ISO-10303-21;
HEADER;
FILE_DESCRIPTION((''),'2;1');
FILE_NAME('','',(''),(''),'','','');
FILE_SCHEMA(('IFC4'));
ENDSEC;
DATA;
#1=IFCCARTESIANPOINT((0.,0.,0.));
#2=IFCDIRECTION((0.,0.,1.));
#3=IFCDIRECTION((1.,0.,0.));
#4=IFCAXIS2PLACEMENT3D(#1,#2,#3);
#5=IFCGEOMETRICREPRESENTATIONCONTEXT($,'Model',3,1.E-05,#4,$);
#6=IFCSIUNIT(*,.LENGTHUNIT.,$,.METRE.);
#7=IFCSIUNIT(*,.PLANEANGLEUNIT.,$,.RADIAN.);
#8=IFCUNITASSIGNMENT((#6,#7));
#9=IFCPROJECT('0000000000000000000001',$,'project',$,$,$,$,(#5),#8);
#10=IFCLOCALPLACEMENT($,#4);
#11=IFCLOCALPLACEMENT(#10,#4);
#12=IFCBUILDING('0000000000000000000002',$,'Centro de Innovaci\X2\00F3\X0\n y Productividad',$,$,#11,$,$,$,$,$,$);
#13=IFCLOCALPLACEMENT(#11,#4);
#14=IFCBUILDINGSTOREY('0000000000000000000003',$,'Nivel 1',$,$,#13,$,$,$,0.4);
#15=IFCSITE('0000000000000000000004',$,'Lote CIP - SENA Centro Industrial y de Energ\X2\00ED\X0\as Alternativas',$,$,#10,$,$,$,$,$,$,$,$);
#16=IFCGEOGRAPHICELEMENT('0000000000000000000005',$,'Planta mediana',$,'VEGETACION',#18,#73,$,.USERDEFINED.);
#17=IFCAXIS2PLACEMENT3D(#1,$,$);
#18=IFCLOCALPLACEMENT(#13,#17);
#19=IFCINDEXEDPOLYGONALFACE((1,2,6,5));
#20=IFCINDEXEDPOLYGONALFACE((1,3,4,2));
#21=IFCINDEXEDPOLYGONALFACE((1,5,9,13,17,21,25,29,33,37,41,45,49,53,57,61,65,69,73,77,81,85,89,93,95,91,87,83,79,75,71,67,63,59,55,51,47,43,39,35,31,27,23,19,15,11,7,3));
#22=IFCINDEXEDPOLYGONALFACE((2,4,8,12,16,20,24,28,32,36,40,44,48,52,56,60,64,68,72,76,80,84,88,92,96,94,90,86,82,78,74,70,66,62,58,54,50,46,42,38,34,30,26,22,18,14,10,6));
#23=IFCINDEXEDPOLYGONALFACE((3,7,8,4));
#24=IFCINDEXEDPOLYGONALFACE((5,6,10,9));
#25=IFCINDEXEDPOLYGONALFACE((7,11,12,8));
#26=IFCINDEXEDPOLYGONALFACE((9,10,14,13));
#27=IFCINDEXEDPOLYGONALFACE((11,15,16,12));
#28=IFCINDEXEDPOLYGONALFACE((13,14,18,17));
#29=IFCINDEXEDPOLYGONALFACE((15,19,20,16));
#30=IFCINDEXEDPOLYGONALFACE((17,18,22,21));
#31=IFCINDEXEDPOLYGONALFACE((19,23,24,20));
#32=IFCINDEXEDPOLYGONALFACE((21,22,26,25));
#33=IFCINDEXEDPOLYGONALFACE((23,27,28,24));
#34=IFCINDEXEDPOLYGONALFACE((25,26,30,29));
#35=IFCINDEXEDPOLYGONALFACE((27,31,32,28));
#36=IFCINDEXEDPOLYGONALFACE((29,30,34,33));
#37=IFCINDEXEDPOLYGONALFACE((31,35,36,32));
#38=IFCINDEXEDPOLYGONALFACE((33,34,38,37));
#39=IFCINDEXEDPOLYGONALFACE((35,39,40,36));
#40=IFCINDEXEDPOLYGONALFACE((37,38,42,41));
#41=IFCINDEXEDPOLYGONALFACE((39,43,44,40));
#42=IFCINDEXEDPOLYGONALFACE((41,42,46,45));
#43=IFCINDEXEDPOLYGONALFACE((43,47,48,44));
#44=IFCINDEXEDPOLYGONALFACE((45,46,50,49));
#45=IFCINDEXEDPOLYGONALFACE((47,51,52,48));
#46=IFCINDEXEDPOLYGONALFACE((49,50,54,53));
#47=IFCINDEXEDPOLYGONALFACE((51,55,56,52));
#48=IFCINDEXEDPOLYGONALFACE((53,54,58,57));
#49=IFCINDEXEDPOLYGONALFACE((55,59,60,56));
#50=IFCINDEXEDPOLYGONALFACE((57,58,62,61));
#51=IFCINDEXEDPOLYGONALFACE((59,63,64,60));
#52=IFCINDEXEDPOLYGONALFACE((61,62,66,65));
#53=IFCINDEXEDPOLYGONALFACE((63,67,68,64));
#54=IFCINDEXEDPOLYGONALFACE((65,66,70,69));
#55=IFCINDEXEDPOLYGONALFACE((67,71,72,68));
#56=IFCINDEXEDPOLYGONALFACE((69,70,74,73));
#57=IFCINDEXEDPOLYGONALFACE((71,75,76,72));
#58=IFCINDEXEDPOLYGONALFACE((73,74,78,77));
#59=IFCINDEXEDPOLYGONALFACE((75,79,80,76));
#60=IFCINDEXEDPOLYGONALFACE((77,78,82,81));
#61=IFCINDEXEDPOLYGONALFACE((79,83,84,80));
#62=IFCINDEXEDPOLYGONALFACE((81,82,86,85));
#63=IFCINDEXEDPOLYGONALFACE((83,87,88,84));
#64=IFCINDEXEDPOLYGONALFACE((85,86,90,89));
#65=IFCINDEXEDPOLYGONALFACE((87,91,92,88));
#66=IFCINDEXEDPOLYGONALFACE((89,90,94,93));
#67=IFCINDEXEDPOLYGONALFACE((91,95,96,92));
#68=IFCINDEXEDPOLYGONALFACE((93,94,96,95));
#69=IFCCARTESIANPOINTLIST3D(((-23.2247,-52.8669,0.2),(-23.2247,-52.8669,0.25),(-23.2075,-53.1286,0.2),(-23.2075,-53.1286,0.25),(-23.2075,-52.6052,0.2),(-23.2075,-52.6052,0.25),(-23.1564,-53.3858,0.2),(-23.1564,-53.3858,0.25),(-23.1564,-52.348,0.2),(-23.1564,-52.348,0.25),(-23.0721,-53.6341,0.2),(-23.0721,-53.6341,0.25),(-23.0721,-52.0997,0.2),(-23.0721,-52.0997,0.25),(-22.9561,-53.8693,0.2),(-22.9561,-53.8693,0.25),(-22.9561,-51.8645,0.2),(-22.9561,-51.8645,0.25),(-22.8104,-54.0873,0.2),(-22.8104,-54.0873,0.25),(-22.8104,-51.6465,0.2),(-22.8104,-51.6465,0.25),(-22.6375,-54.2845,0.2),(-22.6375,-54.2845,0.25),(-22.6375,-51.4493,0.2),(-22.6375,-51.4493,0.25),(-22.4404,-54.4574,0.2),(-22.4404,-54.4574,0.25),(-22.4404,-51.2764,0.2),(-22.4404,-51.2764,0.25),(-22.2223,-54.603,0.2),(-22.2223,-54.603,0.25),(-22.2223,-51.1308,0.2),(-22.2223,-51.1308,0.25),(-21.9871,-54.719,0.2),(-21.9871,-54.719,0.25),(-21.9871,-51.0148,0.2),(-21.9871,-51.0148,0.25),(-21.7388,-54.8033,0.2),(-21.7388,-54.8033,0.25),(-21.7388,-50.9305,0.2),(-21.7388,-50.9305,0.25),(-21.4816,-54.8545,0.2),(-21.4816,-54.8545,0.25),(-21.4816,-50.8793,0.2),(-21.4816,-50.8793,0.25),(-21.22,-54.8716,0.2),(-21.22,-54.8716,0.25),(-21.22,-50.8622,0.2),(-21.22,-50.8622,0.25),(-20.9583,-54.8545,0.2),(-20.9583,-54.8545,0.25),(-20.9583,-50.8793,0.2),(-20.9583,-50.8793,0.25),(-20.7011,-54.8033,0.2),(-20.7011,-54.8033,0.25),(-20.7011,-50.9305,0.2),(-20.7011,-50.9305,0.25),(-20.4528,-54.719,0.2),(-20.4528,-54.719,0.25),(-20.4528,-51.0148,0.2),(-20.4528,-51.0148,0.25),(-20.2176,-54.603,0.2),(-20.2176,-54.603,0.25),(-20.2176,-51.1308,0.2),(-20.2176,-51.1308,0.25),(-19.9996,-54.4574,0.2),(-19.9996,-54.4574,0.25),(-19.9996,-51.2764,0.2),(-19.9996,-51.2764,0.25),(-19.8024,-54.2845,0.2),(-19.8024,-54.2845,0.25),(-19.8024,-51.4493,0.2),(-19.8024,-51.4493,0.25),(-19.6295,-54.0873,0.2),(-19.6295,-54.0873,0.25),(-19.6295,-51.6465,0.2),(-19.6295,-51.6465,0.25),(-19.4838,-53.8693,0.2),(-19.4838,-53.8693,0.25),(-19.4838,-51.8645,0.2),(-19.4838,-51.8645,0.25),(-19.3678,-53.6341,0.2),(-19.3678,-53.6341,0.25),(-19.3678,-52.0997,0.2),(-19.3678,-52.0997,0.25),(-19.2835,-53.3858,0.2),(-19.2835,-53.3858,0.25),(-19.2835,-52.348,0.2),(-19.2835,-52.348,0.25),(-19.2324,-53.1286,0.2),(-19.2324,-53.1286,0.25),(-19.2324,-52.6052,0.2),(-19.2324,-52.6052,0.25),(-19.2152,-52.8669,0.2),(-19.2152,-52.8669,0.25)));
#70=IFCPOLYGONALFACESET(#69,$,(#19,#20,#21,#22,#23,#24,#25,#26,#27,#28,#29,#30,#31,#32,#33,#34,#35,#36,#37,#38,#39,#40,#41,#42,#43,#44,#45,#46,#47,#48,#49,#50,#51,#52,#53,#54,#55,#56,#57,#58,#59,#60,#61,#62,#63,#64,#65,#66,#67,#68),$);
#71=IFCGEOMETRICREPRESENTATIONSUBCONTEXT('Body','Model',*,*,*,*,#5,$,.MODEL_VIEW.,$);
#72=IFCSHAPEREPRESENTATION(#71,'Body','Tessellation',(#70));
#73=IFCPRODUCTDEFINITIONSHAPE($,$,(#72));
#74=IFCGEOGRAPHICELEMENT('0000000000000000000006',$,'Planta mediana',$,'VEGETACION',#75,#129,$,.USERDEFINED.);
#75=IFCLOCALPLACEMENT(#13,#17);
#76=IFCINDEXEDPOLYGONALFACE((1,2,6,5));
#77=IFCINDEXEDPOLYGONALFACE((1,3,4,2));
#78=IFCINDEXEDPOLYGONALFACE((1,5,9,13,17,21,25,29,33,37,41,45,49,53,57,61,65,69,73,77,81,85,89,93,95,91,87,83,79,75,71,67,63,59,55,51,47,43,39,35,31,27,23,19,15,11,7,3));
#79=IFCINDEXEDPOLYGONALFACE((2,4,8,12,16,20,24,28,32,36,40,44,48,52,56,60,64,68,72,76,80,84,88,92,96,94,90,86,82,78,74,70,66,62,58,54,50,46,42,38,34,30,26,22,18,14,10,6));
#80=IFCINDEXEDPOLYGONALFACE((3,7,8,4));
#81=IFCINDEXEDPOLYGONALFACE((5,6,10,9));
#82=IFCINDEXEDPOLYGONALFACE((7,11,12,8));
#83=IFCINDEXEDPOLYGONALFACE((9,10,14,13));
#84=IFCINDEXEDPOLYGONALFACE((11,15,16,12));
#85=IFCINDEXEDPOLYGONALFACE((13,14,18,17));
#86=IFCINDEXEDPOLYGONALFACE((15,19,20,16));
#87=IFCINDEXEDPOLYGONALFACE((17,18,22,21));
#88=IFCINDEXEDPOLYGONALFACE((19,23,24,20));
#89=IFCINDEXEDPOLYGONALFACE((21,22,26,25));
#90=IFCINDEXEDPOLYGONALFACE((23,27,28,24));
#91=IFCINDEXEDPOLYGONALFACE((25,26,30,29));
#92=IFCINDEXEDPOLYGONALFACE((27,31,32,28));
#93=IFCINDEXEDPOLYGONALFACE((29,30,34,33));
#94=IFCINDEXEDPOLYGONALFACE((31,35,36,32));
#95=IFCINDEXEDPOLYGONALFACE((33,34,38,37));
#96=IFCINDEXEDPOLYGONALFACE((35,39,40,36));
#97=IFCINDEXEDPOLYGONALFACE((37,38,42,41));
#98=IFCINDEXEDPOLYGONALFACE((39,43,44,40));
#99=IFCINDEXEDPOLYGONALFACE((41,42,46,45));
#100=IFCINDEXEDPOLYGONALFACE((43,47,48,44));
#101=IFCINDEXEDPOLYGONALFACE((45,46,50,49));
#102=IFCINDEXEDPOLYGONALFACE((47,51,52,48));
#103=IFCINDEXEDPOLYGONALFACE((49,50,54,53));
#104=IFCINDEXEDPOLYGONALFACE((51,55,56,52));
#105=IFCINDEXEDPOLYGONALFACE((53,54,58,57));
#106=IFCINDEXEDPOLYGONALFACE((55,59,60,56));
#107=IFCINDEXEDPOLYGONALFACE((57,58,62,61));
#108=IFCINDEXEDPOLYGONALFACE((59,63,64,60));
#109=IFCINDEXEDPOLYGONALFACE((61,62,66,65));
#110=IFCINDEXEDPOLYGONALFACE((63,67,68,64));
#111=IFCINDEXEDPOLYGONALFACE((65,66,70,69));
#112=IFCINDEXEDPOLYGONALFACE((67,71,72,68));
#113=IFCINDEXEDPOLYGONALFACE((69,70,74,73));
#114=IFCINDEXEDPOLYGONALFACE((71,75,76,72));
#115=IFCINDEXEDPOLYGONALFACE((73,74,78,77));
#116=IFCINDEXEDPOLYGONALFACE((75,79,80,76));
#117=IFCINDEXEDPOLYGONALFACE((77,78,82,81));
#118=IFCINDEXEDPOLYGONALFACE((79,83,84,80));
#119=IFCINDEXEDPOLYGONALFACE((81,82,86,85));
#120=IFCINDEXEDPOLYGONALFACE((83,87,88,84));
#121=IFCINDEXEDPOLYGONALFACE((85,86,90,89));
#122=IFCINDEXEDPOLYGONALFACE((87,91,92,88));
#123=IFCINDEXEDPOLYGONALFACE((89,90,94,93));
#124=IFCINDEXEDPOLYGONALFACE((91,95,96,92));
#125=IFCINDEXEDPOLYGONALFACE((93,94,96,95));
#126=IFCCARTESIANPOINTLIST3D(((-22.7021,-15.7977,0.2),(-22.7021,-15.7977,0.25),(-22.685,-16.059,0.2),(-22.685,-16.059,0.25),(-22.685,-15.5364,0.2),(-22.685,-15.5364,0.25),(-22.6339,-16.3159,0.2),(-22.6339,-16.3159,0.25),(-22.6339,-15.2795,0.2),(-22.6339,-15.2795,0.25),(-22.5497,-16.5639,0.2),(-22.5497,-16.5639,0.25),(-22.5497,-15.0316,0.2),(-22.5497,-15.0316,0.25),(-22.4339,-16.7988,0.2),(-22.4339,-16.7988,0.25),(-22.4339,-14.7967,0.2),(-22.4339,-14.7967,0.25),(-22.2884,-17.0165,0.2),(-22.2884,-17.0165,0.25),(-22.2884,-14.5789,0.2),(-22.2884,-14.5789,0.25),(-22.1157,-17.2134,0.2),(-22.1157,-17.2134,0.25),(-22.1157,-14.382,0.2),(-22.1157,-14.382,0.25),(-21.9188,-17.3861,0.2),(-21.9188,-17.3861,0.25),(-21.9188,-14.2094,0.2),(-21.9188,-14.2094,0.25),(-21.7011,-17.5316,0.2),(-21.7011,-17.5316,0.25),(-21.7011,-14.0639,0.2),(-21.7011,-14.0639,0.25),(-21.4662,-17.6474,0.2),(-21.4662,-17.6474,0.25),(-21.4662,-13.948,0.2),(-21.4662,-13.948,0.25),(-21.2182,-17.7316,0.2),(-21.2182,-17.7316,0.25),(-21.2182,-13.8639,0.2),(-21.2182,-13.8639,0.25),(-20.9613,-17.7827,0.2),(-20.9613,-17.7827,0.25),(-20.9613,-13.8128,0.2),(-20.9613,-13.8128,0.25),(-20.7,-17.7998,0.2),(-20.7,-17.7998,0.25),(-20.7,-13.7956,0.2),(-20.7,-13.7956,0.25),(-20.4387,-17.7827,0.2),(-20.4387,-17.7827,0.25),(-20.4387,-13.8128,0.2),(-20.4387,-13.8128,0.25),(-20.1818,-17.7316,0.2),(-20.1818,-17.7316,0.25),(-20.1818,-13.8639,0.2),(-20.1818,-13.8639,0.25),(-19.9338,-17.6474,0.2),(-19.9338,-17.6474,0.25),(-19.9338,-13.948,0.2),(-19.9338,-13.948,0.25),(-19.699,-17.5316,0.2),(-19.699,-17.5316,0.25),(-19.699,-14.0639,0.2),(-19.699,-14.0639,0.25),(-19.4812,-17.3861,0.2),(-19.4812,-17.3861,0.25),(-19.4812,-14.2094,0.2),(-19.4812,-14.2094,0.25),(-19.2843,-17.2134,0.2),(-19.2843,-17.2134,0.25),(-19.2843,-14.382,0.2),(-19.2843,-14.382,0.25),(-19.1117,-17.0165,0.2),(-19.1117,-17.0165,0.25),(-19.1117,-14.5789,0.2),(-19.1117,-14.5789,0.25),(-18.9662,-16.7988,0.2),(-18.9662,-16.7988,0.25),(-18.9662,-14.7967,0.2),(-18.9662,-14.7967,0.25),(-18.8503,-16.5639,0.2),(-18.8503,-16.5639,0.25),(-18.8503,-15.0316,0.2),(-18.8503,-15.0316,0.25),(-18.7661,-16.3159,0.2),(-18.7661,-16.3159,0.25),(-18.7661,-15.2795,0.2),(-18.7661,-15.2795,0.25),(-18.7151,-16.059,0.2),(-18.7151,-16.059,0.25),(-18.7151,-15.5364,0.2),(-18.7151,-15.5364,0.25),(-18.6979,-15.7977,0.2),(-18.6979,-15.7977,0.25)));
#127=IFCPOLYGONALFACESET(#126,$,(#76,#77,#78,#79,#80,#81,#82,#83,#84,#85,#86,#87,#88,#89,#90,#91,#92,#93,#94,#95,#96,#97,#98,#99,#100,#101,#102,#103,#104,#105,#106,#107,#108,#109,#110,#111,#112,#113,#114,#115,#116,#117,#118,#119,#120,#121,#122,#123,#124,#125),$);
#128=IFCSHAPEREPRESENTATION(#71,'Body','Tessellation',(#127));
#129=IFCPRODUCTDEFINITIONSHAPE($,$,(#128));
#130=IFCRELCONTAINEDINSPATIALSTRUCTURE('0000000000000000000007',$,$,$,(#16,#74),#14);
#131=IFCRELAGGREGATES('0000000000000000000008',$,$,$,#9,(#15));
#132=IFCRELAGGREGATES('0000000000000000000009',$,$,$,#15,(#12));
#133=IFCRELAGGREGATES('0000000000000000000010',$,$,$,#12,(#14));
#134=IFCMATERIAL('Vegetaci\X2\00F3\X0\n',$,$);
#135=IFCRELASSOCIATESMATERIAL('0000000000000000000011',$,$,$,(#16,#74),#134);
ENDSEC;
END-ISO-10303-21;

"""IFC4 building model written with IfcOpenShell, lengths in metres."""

from ifc_helpers import new_model, si_unit, frame, origin_with_axes, place, context, subcontext, project, spatial, polyline, outline, extrude, material, element, save


model = new_model("IFC4")

# Units and contexts
model_context = context("Model", 3, precision=1e-05, world=origin_with_axes())
body_context = subcontext(model_context, "Body", "Model", "MODEL_VIEW")
ifc_project = project(units=[si_unit("LENGTHUNIT", "METRE"), si_unit("PLANEANGLEUNIT", "RADIAN")], contexts=[model_context])

# Site, building, storey
site_placement = place(None, origin_with_axes())
site = spatial("IfcSite", under=ifc_project, at=site_placement, Name="Lote CIP - SENA Centro Industrial y de Energías Alternativas")
building_placement = place(site_placement, origin_with_axes())
building = spatial("IfcBuilding", under=site, at=building_placement, Name="Centro de Innovación y Productividad")
storey_placement = place(building_placement, origin_with_axes())
storey = spatial("IfcBuildingStorey", under=building, at=storey_placement, Name="Nivel 1", Elevation=0.4)

# Geographic elements
ifc_material_1 = material(Name="Vegetación")
geographic_element_1_placement = place(storey_placement, origin_with_axes())
element("IfcGeographicElement", 1, at=geographic_element_1_placement, inside=storey, material=ifc_material_1, Name="Planta mediana", ObjectType="VEGETACION", PredefinedType="USERDEFINED", context=body_context, shape_type="SweptSolid", body=[
    extrude(outline(polyline([(-19.2152, -52.8669), (-19.2324, -53.1286), (-19.2835, -53.3858), (-19.3678, -53.6341), (-19.4838, -53.8693), (-19.6295, -54.0873), (-19.8024, -54.2845), (-19.9996, -54.4574), (-20.2176, -54.603), (-20.4528, -54.719), (-20.7011, -54.8033), (-20.9583, -54.8545), (-21.22, -54.8716), (-21.4816, -54.8545), (-21.7388, -54.8033), (-21.9871, -54.719), (-22.2223, -54.603), (-22.4404, -54.4574), (-22.6375, -54.2845), (-22.8104, -54.0873), (-22.9561, -53.8693), (-23.0721, -53.6341), (-23.1564, -53.3858), (-23.2075, -53.1286), (-23.2247, -52.8669), (-23.2075, -52.6052), (-23.1564, -52.348), (-23.0721, -52.0997), (-22.9561, -51.8645), (-22.8104, -51.6465), (-22.6375, -51.4493), (-22.4404, -51.2764), (-22.2223, -51.1308), (-21.9871, -51.0148), (-21.7388, -50.9305), (-21.4816, -50.8793), (-21.22, -50.8622), (-20.9583, -50.8793), (-20.7011, -50.9305), (-20.4528, -51.0148), (-20.2176, -51.1308), (-19.9996, -51.2764), (-19.8024, -51.4493), (-19.6295, -51.6465), (-19.4838, -51.8645), (-19.3678, -52.0997), (-19.2835, -52.348), (-19.2324, -52.6052), (-19.2152, -52.8669)])), frame((0.0, 0.0, 0.2)), (0.0, 0.0, 1.0), 0.05),
])
geographic_element_2_placement = place(storey_placement, origin_with_axes())
element("IfcGeographicElement", 2, at=geographic_element_2_placement, inside=storey, material=ifc_material_1, Name="Planta mediana", ObjectType="VEGETACION", PredefinedType="USERDEFINED", context=body_context, shape_type="SweptSolid", body=[
    extrude(outline(polyline([(-18.6979, -15.7977), (-18.7151, -16.059), (-18.7661, -16.3159), (-18.8503, -16.5639), (-18.9662, -16.7988), (-19.1117, -17.0165), (-19.2843, -17.2134), (-19.4812, -17.3861), (-19.699, -17.5316), (-19.9338, -17.6474), (-20.1818, -17.7316), (-20.4387, -17.7827), (-20.7, -17.7998), (-20.9613, -17.7827), (-21.2182, -17.7316), (-21.4662, -17.6474), (-21.7011, -17.5316), (-21.9188, -17.3861), (-22.1157, -17.2134), (-22.2884, -17.0165), (-22.4339, -16.7988), (-22.5497, -16.5639), (-22.6339, -16.3159), (-22.685, -16.059), (-22.7021, -15.7977), (-22.685, -15.5364), (-22.6339, -15.2795), (-22.5497, -15.0316), (-22.4339, -14.7967), (-22.2884, -14.5789), (-22.1157, -14.382), (-21.9188, -14.2094), (-21.7011, -14.0639), (-21.4662, -13.948), (-21.2182, -13.8639), (-20.9613, -13.8128), (-20.7, -13.7956), (-20.4387, -13.8128), (-20.1818, -13.8639), (-19.9338, -13.948), (-19.699, -14.0639), (-19.4812, -14.2094), (-19.2843, -14.382), (-19.1117, -14.5789), (-18.9662, -14.7967), (-18.8503, -15.0316), (-18.7661, -15.2795), (-18.7151, -15.5364), (-18.6979, -15.7977)])), frame((0.0, 0.0, 0.2)), (0.0, 0.0, 1.0), 0.05),
])

save(model, "model.ifc")
